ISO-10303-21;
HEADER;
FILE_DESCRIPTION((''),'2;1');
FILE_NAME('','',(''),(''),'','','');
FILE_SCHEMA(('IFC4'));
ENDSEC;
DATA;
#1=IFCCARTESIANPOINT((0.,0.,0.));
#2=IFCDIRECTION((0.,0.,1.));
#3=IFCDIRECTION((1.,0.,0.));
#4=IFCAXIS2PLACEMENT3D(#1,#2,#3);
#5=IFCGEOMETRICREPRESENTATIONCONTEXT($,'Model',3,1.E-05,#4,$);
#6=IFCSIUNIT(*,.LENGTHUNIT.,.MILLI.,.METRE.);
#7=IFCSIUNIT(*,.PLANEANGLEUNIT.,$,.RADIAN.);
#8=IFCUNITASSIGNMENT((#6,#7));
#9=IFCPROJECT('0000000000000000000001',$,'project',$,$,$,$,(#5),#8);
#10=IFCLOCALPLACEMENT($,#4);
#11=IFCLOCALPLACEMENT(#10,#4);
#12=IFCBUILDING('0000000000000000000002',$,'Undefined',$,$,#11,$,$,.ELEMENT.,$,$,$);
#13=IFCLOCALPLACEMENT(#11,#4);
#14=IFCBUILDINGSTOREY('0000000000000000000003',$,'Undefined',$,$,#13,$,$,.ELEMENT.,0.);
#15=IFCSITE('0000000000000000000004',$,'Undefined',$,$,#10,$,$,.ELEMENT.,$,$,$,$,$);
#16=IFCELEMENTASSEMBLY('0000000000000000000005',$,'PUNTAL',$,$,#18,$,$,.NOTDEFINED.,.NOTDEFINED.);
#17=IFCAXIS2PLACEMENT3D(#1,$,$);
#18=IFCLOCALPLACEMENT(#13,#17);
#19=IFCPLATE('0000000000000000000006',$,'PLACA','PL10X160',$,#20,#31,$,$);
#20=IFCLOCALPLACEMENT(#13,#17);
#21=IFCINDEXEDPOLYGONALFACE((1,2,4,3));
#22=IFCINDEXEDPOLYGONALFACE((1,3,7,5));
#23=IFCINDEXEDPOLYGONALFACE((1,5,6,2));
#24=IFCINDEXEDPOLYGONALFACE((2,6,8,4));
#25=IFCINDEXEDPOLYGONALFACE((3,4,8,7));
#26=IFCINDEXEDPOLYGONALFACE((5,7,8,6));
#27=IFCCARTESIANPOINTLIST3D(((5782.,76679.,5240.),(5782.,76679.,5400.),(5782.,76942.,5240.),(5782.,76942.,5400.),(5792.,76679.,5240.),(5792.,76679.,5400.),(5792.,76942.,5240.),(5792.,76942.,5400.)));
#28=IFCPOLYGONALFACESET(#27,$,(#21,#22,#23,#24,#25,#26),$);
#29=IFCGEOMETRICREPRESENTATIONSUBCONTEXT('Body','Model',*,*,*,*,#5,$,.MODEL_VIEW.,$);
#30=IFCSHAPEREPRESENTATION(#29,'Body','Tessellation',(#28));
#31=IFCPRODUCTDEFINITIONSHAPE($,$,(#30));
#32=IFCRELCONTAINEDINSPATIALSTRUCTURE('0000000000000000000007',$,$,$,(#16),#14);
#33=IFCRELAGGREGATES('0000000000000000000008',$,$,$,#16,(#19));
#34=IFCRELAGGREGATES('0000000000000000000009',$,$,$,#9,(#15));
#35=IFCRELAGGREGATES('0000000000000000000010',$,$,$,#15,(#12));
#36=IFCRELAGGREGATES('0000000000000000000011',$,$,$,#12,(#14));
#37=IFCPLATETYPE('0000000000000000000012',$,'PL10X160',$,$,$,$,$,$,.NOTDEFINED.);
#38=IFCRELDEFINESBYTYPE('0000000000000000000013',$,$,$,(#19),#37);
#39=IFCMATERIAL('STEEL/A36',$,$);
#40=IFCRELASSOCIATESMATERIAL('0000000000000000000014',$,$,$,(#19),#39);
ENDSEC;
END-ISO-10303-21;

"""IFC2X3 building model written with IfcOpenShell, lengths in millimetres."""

from ifc_helpers import new_model, si_unit, frame, origin_with_axes, place, context, subcontext, project, spatial, polyline, outline, extrude, material, type_object, element, aggregate, save


model = new_model("IFC2X3")

# Units and contexts
model_context = context("Model", 3, precision=1e-05, world=origin_with_axes())
body_context = subcontext(model_context, "Body", "Model", "MODEL_VIEW")
ifc_project = project(units=[si_unit("LENGTHUNIT", "METRE", prefix="MILLI"), si_unit("PLANEANGLEUNIT", "RADIAN")], contexts=[model_context])

# Site, building, storey
site_placement = place(None, origin_with_axes())
site = spatial("IfcSite", under=ifc_project, at=site_placement, Name="Undefined", CompositionType="ELEMENT")
building_placement = place(site_placement, origin_with_axes())
building = spatial("IfcBuilding", under=site, at=building_placement, Name="Undefined", CompositionType="ELEMENT")
storey_placement = place(building_placement, origin_with_axes())
storey = spatial("IfcBuildingStorey", under=building, at=storey_placement, Name="Undefined", CompositionType="ELEMENT", Elevation=0.0)

# Shared definitions
ifc_material_1 = material(Name="STEEL/A36")

# Element assembly
assembly_1_placement = place(storey_placement, origin_with_axes())
assembly_1 = element("IfcElementAssembly", 1, at=assembly_1_placement, inside=storey, Name="PUNTAL", AssemblyPlace="NOTDEFINED", PredefinedType="NOTDEFINED")

# Plate
plate_type_1 = type_object("IfcPlateType", Name="PL10X160", PredefinedType="NOTDEFINED")
plate_1_placement = place(assembly_1_placement, frame((5787.0, 76942.0, 5320.0), z_axis=(1.0, 0.0, 0.0), x_axis=(0.0, -1.0, 0.0)))
plate_1 = element("IfcPlate", 2, at=plate_1_placement, type_object=plate_type_1, material=ifc_material_1, Name="PLACA", Description="PL10X160", context=body_context, shape_type="SweptSolid", body=[
    extrude(outline(polyline([(0.0, -80.0), (0.0, 80.0), (263.0, 80.0), (263.0, -80.0), (0.0, -80.0)])), frame((0.0, 0.0, -5.0), z_axis=(0.0, 0.0, 1.0), x_axis=(1.0, 0.0, 0.0)), (0.0, 0.0, 1.0), 10.0),
])
aggregate(assembly_1, [plate_1])

save(model, "model.ifc")
